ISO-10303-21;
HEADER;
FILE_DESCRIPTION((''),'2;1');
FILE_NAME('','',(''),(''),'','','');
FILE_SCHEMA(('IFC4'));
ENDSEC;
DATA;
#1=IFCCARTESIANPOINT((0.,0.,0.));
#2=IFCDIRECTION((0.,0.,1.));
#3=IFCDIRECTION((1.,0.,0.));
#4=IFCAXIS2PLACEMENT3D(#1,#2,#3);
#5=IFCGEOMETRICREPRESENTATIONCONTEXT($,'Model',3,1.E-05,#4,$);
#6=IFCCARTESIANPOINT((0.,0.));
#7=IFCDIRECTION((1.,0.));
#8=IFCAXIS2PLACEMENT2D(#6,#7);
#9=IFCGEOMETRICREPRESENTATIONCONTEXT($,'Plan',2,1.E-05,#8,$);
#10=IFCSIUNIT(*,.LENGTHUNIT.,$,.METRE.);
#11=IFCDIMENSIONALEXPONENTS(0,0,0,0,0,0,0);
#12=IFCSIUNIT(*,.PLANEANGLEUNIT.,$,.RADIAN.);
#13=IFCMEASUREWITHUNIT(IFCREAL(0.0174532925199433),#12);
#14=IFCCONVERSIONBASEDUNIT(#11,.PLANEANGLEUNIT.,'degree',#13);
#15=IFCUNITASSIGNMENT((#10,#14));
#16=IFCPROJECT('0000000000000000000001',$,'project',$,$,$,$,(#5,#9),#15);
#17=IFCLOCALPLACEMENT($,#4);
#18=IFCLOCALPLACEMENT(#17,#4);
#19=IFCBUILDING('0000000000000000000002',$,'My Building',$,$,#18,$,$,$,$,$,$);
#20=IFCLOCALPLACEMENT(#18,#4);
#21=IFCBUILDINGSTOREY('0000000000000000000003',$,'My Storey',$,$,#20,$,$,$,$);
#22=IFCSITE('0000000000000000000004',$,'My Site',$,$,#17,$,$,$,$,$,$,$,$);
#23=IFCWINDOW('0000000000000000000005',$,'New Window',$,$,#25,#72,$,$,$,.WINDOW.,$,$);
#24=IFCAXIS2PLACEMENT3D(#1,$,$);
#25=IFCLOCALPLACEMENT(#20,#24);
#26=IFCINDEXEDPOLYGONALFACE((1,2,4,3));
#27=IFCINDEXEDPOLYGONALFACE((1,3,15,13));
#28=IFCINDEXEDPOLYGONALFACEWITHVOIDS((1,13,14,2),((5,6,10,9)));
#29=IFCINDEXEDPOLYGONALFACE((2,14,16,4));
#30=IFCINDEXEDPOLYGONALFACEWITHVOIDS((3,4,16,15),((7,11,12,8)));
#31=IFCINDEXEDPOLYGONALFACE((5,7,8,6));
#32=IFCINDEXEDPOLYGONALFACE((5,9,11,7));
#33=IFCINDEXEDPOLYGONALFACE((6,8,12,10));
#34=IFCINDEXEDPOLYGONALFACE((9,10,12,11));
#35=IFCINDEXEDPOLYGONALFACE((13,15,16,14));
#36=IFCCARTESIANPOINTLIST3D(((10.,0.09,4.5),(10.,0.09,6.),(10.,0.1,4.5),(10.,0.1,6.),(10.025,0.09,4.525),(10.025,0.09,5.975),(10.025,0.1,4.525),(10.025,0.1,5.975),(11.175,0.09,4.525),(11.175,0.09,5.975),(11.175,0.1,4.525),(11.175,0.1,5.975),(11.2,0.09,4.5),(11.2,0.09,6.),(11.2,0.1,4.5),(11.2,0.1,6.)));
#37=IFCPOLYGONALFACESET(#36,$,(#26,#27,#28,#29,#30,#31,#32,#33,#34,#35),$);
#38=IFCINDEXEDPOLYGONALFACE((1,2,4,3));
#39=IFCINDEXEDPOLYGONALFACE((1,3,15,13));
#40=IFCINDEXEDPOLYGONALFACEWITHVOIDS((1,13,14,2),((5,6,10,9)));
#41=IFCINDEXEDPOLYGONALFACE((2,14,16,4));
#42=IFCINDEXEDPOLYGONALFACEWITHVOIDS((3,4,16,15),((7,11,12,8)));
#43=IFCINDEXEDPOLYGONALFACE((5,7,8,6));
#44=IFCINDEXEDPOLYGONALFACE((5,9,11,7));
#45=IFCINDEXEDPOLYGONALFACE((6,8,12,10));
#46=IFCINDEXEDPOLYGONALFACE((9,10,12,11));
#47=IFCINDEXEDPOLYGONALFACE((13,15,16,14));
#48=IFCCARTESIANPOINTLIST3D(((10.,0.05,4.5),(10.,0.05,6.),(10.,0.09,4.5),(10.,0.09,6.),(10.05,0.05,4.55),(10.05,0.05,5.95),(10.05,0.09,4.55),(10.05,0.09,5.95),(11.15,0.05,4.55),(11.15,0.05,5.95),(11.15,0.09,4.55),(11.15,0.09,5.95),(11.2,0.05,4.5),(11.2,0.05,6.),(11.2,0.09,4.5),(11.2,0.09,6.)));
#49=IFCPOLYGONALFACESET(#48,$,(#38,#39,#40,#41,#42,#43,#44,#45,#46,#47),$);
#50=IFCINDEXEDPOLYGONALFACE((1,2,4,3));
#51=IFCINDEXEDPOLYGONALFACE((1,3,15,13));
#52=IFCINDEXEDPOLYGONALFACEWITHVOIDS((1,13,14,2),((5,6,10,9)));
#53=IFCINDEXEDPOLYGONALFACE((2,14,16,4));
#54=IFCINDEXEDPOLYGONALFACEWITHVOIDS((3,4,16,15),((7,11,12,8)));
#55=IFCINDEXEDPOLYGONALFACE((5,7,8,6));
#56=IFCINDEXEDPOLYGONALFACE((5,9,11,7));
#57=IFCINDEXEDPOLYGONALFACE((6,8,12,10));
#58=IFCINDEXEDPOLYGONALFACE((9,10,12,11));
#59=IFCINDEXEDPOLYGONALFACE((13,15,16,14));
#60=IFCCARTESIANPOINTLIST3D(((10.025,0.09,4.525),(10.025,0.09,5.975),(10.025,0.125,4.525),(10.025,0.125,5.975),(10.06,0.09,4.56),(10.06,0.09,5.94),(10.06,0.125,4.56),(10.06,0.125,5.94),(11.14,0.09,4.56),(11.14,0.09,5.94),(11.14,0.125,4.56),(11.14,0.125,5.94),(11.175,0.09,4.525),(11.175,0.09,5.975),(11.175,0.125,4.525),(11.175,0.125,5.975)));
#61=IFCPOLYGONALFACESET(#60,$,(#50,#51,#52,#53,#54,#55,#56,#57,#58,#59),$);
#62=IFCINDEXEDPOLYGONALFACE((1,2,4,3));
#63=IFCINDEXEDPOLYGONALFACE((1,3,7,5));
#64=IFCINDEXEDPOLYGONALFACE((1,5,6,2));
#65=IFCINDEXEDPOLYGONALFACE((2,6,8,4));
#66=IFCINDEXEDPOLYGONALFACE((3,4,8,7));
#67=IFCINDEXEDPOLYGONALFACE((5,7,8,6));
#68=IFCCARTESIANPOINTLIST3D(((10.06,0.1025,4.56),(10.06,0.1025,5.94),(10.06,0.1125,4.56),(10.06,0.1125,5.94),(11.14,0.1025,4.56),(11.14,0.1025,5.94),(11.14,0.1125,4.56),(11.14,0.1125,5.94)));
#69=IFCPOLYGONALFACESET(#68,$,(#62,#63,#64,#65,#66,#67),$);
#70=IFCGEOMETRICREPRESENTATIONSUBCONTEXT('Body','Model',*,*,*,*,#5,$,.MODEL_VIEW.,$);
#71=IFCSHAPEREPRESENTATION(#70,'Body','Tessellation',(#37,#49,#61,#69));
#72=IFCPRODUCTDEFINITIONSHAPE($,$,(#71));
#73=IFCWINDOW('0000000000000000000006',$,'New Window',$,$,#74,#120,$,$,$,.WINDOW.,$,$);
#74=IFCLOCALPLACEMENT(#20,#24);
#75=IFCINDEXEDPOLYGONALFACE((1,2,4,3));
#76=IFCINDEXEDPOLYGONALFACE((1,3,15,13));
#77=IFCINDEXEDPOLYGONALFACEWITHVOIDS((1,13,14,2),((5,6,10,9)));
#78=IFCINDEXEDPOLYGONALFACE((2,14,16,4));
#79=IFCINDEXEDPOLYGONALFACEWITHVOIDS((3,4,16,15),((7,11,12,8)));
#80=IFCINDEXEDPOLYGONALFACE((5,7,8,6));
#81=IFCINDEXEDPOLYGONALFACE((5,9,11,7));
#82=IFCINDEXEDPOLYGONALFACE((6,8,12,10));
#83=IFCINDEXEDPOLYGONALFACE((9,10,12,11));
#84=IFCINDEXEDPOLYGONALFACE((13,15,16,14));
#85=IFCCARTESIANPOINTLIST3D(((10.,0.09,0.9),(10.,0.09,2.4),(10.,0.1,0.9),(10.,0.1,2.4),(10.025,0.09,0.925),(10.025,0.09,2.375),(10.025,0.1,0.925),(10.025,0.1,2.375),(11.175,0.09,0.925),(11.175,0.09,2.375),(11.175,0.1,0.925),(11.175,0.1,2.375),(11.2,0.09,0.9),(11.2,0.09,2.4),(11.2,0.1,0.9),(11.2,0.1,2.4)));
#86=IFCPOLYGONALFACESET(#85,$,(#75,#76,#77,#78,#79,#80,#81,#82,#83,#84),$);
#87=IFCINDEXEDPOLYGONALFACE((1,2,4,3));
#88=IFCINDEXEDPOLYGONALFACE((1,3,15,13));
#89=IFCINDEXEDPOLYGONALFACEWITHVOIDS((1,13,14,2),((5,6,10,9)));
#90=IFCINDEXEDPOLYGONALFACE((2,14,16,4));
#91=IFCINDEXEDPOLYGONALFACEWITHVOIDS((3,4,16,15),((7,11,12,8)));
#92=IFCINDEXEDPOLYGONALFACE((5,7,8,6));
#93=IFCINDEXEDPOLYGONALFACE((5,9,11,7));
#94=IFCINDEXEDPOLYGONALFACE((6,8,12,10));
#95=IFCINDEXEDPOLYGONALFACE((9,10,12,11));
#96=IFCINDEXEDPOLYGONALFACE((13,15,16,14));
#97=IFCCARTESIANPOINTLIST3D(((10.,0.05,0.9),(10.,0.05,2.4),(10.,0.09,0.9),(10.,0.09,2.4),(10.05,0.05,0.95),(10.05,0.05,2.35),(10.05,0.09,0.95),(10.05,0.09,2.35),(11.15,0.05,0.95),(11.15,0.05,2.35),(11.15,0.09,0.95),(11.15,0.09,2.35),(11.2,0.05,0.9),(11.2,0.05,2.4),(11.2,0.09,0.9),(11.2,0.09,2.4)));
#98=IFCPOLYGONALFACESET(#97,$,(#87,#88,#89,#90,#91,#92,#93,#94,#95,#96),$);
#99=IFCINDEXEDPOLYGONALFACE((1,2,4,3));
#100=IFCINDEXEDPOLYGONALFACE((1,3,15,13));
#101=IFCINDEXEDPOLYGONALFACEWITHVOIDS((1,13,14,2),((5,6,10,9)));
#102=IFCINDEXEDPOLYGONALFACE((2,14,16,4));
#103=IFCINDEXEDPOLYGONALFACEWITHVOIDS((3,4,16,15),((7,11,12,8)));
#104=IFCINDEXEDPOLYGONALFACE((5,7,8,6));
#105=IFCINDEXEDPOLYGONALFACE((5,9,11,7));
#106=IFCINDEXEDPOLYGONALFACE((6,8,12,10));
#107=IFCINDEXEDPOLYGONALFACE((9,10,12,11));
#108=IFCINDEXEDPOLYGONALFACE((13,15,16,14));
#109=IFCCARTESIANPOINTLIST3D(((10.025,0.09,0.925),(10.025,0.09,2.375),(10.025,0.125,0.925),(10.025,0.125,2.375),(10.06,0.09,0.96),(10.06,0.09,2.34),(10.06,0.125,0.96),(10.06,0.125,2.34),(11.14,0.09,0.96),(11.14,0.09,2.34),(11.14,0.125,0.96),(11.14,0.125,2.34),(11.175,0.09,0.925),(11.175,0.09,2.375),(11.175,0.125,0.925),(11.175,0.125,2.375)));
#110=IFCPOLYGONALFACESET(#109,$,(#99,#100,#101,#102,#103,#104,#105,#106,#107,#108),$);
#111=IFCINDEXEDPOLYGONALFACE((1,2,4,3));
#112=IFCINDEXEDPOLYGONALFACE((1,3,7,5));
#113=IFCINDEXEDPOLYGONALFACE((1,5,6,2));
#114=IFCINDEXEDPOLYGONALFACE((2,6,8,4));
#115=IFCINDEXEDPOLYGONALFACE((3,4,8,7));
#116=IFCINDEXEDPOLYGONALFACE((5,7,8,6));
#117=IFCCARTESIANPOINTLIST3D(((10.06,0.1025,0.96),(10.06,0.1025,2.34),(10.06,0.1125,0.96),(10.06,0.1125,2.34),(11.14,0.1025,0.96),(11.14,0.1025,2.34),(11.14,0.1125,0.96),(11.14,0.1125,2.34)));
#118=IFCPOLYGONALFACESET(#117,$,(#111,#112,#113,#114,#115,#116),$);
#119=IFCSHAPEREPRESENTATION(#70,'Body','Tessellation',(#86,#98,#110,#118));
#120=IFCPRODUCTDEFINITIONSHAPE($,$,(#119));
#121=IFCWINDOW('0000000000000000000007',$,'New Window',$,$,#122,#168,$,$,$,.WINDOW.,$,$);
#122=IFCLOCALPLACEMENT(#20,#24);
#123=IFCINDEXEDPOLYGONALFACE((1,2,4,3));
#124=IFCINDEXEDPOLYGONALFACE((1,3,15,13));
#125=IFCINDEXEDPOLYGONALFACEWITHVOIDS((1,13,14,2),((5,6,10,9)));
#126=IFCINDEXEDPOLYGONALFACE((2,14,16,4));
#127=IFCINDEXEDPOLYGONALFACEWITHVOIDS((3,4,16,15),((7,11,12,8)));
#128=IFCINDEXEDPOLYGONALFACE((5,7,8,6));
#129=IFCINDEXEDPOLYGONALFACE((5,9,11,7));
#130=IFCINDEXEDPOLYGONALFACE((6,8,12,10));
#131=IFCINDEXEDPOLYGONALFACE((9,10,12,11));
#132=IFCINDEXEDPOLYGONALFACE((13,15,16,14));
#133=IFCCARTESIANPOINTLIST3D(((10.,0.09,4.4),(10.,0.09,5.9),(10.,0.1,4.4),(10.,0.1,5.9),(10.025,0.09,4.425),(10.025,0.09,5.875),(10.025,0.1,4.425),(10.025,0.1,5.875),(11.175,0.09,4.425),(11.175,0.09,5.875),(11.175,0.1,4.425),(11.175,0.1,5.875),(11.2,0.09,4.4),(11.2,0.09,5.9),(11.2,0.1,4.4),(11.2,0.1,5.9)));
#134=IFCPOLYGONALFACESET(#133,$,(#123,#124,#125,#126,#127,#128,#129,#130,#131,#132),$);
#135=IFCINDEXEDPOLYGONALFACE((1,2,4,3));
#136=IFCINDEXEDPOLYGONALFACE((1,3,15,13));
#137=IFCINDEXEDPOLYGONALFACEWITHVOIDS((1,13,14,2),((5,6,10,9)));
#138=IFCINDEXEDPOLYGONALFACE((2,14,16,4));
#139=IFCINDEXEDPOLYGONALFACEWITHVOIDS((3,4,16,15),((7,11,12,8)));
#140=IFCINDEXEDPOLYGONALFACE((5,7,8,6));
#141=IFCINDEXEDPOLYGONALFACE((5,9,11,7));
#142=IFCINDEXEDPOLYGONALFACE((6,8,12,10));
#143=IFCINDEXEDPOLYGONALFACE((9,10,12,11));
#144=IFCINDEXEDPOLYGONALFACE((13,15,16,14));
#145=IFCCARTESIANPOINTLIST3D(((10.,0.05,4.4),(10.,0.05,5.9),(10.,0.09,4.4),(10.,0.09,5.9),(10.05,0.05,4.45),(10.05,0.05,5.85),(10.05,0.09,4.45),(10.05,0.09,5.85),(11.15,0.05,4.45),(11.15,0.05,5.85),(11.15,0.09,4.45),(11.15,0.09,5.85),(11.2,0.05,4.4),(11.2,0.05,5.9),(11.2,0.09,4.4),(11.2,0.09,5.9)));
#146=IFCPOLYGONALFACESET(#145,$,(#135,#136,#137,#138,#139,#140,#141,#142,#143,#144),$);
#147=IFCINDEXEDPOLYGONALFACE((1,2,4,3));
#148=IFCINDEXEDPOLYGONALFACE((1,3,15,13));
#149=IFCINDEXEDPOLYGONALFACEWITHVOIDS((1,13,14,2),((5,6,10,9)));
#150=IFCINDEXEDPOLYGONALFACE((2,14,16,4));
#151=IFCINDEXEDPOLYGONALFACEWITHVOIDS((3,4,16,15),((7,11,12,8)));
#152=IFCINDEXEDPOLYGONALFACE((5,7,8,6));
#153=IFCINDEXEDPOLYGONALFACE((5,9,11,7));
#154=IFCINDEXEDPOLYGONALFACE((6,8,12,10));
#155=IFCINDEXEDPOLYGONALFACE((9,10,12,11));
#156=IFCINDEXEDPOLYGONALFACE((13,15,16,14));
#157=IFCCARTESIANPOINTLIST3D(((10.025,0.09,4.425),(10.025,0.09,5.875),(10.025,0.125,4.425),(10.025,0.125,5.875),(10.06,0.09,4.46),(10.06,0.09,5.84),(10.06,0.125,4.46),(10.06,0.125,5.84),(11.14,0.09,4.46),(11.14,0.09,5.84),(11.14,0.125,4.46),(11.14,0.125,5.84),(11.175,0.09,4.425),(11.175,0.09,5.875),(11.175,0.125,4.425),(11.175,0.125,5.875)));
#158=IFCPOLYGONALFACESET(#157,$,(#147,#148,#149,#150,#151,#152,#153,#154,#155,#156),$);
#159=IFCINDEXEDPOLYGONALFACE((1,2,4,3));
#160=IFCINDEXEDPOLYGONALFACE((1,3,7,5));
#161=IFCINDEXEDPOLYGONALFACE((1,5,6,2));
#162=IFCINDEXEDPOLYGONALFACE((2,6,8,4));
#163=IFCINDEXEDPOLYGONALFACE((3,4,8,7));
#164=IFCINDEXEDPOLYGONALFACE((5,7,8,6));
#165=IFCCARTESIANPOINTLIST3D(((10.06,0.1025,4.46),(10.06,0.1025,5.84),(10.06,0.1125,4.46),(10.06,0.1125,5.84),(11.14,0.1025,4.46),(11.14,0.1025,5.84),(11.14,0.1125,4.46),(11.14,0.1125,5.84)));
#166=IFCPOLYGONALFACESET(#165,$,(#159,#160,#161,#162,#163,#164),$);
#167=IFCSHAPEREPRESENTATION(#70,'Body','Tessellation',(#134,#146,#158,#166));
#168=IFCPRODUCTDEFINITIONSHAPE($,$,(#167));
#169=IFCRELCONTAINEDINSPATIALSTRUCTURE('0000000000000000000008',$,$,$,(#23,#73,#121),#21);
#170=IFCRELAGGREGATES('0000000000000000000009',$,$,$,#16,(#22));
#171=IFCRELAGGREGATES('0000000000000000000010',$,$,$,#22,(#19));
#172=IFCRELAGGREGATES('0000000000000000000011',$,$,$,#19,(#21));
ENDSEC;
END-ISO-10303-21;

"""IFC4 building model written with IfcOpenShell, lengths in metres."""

from ifc_helpers import new_model, entity, si_unit, converted_unit, frame, origin_with_axes, origin_2d_with_axis, place, context, subcontext, project, spatial, line, indexed_curve, outline, extrude, element, save


model = new_model("IFC4")

# Units and contexts
model_context = context("Model", 3, precision=1e-05, world=origin_with_axes())
plan_context = context("Plan", 2, precision=1e-05, world=origin_2d_with_axis())
body_context = subcontext(model_context, "Body", "Model", "MODEL_VIEW")
ifc_project = project(units=[si_unit("LENGTHUNIT", "METRE"), converted_unit("PLANEANGLEUNIT", "degree", entity("IfcReal", 0.0174532925199433), si_unit("PLANEANGLEUNIT", "RADIAN"), dimensions=[0, 0, 0, 0, 0, 0, 0])], contexts=[model_context, plan_context])

# Site, building, storey
site_placement = place(None, origin_with_axes())
site = spatial("IfcSite", under=ifc_project, at=site_placement, Name="My Site")
building_placement = place(site_placement, origin_with_axes())
building = spatial("IfcBuilding", under=site, at=building_placement, Name="My Building")
storey_placement = place(building_placement, origin_with_axes())
storey = spatial("IfcBuildingStorey", under=building, at=storey_placement, Name="My Storey")

# Window
window_placement = place(storey_placement, frame((10.0, 0.0, 4.5), z_axis=(0.0, 0.0, 1.0), x_axis=(1.0, 0.0, 0.0)))
element("IfcWindow", 1, at=window_placement, inside=storey, Name="New Window", PredefinedType="WINDOW", context=body_context, shape_type="SweptSolid", body=[
    extrude(outline(indexed_curve([(0.0, 0.0), (1.2, 0.0), (1.2, 1.5), (0.0, 1.5)], segments=[line(1, 2, 3, 4, 1)]), holes=[indexed_curve([(0.025, 0.025), (1.175, 0.025), (1.175, 1.475), (0.025, 1.475)], segments=[line(1, 2, 3, 4, 1)])]), frame((0.0, 0.09, 0.0), z_axis=(0.0, -1.0, 0.0), x_axis=(1.0, 0.0, 0.0)), (0.0, 0.0, -1.0), 0.01),
    extrude(outline(indexed_curve([(0.0, 0.0), (1.2, 0.0), (1.2, 1.5), (0.0, 1.5)], segments=[line(1, 2, 3, 4, 1)]), holes=[indexed_curve([(0.05, 0.05), (1.15, 0.05), (1.15, 1.45), (0.05, 1.45)], segments=[line(1, 2, 3, 4, 1)])]), frame((0.0, 0.05, 0.0), z_axis=(0.0, -1.0, 0.0), x_axis=(1.0, 0.0, 0.0)), (0.0, 0.0, -1.0), 0.04),
    extrude(outline(indexed_curve([(0.0, 0.0), (1.15, 0.0), (1.15, 1.45), (0.0, 1.45)], segments=[line(1, 2, 3, 4, 1)]), holes=[indexed_curve([(0.035, 0.035), (1.115, 0.035), (1.115, 1.415), (0.035, 1.415)], segments=[line(1, 2, 3, 4, 1)])]), frame((0.025, 0.09, 0.025), z_axis=(0.0, -1.0, 0.0), x_axis=(1.0, 0.0, 0.0)), (0.0, 0.0, -1.0), 0.035),
    extrude(outline(indexed_curve([(0.035, 0.035), (1.115, 0.035), (1.115, 1.415), (0.035, 1.415)], segments=[line(1, 2, 3, 4, 1)])), frame((0.025, 0.1025, 0.025), z_axis=(0.0, -1.0, 0.0), x_axis=(1.0, 0.0, 0.0)), (0.0, 0.0, -1.0), 0.01),
])

# Windows
for number, where, z_axis, x_axis, name in (
    (2, (10.0, 0.0, 0.9), (0.0, 0.0, 1.0), (1.0, 0.0, 0.0), "New Window"),
    (3, (10.0, 0.0, 4.4), (0.0, 0.0, 1.0), (1.0, 0.0, 0.0), "New Window"),
):
    element("IfcWindow", number, at=place(storey_placement, frame(where, z_axis=z_axis, x_axis=x_axis)), inside=storey, Name=name, PredefinedType="WINDOW", context=body_context, shape_type="SweptSolid", body=[
        extrude(outline(indexed_curve([(0.0, 0.0), (1.2, 0.0), (1.2, 1.5), (0.0, 1.5)], segments=[line(1, 2, 3, 4, 1)]), holes=[indexed_curve([(0.025, 0.025), (1.175, 0.025), (1.175, 1.475), (0.025, 1.475)], segments=[line(1, 2, 3, 4, 1)])]), frame((0.0, 0.09, 0.0), z_axis=(0.0, -1.0, 0.0), x_axis=(1.0, 0.0, 0.0)), (0.0, 0.0, -1.0), 0.01),
        extrude(outline(indexed_curve([(0.0, 0.0), (1.2, 0.0), (1.2, 1.5), (0.0, 1.5)], segments=[line(1, 2, 3, 4, 1)]), holes=[indexed_curve([(0.05, 0.05), (1.15, 0.05), (1.15, 1.45), (0.05, 1.45)], segments=[line(1, 2, 3, 4, 1)])]), frame((0.0, 0.05, 0.0), z_axis=(0.0, -1.0, 0.0), x_axis=(1.0, 0.0, 0.0)), (0.0, 0.0, -1.0), 0.04),
        extrude(outline(indexed_curve([(0.0, 0.0), (1.15, 0.0), (1.15, 1.45), (0.0, 1.45)], segments=[line(1, 2, 3, 4, 1)]), holes=[indexed_curve([(0.035, 0.035), (1.115, 0.035), (1.115, 1.415), (0.035, 1.415)], segments=[line(1, 2, 3, 4, 1)])]), frame((0.025, 0.09, 0.025), z_axis=(0.0, -1.0, 0.0), x_axis=(1.0, 0.0, 0.0)), (0.0, 0.0, -1.0), 0.035),
        extrude(outline(indexed_curve([(0.035, 0.035), (1.115, 0.035), (1.115, 1.415), (0.035, 1.415)], segments=[line(1, 2, 3, 4, 1)])), frame((0.025, 0.1025, 0.025), z_axis=(0.0, -1.0, 0.0), x_axis=(1.0, 0.0, 0.0)), (0.0, 0.0, -1.0), 0.01),
    ])

save(model, "model.ifc")
